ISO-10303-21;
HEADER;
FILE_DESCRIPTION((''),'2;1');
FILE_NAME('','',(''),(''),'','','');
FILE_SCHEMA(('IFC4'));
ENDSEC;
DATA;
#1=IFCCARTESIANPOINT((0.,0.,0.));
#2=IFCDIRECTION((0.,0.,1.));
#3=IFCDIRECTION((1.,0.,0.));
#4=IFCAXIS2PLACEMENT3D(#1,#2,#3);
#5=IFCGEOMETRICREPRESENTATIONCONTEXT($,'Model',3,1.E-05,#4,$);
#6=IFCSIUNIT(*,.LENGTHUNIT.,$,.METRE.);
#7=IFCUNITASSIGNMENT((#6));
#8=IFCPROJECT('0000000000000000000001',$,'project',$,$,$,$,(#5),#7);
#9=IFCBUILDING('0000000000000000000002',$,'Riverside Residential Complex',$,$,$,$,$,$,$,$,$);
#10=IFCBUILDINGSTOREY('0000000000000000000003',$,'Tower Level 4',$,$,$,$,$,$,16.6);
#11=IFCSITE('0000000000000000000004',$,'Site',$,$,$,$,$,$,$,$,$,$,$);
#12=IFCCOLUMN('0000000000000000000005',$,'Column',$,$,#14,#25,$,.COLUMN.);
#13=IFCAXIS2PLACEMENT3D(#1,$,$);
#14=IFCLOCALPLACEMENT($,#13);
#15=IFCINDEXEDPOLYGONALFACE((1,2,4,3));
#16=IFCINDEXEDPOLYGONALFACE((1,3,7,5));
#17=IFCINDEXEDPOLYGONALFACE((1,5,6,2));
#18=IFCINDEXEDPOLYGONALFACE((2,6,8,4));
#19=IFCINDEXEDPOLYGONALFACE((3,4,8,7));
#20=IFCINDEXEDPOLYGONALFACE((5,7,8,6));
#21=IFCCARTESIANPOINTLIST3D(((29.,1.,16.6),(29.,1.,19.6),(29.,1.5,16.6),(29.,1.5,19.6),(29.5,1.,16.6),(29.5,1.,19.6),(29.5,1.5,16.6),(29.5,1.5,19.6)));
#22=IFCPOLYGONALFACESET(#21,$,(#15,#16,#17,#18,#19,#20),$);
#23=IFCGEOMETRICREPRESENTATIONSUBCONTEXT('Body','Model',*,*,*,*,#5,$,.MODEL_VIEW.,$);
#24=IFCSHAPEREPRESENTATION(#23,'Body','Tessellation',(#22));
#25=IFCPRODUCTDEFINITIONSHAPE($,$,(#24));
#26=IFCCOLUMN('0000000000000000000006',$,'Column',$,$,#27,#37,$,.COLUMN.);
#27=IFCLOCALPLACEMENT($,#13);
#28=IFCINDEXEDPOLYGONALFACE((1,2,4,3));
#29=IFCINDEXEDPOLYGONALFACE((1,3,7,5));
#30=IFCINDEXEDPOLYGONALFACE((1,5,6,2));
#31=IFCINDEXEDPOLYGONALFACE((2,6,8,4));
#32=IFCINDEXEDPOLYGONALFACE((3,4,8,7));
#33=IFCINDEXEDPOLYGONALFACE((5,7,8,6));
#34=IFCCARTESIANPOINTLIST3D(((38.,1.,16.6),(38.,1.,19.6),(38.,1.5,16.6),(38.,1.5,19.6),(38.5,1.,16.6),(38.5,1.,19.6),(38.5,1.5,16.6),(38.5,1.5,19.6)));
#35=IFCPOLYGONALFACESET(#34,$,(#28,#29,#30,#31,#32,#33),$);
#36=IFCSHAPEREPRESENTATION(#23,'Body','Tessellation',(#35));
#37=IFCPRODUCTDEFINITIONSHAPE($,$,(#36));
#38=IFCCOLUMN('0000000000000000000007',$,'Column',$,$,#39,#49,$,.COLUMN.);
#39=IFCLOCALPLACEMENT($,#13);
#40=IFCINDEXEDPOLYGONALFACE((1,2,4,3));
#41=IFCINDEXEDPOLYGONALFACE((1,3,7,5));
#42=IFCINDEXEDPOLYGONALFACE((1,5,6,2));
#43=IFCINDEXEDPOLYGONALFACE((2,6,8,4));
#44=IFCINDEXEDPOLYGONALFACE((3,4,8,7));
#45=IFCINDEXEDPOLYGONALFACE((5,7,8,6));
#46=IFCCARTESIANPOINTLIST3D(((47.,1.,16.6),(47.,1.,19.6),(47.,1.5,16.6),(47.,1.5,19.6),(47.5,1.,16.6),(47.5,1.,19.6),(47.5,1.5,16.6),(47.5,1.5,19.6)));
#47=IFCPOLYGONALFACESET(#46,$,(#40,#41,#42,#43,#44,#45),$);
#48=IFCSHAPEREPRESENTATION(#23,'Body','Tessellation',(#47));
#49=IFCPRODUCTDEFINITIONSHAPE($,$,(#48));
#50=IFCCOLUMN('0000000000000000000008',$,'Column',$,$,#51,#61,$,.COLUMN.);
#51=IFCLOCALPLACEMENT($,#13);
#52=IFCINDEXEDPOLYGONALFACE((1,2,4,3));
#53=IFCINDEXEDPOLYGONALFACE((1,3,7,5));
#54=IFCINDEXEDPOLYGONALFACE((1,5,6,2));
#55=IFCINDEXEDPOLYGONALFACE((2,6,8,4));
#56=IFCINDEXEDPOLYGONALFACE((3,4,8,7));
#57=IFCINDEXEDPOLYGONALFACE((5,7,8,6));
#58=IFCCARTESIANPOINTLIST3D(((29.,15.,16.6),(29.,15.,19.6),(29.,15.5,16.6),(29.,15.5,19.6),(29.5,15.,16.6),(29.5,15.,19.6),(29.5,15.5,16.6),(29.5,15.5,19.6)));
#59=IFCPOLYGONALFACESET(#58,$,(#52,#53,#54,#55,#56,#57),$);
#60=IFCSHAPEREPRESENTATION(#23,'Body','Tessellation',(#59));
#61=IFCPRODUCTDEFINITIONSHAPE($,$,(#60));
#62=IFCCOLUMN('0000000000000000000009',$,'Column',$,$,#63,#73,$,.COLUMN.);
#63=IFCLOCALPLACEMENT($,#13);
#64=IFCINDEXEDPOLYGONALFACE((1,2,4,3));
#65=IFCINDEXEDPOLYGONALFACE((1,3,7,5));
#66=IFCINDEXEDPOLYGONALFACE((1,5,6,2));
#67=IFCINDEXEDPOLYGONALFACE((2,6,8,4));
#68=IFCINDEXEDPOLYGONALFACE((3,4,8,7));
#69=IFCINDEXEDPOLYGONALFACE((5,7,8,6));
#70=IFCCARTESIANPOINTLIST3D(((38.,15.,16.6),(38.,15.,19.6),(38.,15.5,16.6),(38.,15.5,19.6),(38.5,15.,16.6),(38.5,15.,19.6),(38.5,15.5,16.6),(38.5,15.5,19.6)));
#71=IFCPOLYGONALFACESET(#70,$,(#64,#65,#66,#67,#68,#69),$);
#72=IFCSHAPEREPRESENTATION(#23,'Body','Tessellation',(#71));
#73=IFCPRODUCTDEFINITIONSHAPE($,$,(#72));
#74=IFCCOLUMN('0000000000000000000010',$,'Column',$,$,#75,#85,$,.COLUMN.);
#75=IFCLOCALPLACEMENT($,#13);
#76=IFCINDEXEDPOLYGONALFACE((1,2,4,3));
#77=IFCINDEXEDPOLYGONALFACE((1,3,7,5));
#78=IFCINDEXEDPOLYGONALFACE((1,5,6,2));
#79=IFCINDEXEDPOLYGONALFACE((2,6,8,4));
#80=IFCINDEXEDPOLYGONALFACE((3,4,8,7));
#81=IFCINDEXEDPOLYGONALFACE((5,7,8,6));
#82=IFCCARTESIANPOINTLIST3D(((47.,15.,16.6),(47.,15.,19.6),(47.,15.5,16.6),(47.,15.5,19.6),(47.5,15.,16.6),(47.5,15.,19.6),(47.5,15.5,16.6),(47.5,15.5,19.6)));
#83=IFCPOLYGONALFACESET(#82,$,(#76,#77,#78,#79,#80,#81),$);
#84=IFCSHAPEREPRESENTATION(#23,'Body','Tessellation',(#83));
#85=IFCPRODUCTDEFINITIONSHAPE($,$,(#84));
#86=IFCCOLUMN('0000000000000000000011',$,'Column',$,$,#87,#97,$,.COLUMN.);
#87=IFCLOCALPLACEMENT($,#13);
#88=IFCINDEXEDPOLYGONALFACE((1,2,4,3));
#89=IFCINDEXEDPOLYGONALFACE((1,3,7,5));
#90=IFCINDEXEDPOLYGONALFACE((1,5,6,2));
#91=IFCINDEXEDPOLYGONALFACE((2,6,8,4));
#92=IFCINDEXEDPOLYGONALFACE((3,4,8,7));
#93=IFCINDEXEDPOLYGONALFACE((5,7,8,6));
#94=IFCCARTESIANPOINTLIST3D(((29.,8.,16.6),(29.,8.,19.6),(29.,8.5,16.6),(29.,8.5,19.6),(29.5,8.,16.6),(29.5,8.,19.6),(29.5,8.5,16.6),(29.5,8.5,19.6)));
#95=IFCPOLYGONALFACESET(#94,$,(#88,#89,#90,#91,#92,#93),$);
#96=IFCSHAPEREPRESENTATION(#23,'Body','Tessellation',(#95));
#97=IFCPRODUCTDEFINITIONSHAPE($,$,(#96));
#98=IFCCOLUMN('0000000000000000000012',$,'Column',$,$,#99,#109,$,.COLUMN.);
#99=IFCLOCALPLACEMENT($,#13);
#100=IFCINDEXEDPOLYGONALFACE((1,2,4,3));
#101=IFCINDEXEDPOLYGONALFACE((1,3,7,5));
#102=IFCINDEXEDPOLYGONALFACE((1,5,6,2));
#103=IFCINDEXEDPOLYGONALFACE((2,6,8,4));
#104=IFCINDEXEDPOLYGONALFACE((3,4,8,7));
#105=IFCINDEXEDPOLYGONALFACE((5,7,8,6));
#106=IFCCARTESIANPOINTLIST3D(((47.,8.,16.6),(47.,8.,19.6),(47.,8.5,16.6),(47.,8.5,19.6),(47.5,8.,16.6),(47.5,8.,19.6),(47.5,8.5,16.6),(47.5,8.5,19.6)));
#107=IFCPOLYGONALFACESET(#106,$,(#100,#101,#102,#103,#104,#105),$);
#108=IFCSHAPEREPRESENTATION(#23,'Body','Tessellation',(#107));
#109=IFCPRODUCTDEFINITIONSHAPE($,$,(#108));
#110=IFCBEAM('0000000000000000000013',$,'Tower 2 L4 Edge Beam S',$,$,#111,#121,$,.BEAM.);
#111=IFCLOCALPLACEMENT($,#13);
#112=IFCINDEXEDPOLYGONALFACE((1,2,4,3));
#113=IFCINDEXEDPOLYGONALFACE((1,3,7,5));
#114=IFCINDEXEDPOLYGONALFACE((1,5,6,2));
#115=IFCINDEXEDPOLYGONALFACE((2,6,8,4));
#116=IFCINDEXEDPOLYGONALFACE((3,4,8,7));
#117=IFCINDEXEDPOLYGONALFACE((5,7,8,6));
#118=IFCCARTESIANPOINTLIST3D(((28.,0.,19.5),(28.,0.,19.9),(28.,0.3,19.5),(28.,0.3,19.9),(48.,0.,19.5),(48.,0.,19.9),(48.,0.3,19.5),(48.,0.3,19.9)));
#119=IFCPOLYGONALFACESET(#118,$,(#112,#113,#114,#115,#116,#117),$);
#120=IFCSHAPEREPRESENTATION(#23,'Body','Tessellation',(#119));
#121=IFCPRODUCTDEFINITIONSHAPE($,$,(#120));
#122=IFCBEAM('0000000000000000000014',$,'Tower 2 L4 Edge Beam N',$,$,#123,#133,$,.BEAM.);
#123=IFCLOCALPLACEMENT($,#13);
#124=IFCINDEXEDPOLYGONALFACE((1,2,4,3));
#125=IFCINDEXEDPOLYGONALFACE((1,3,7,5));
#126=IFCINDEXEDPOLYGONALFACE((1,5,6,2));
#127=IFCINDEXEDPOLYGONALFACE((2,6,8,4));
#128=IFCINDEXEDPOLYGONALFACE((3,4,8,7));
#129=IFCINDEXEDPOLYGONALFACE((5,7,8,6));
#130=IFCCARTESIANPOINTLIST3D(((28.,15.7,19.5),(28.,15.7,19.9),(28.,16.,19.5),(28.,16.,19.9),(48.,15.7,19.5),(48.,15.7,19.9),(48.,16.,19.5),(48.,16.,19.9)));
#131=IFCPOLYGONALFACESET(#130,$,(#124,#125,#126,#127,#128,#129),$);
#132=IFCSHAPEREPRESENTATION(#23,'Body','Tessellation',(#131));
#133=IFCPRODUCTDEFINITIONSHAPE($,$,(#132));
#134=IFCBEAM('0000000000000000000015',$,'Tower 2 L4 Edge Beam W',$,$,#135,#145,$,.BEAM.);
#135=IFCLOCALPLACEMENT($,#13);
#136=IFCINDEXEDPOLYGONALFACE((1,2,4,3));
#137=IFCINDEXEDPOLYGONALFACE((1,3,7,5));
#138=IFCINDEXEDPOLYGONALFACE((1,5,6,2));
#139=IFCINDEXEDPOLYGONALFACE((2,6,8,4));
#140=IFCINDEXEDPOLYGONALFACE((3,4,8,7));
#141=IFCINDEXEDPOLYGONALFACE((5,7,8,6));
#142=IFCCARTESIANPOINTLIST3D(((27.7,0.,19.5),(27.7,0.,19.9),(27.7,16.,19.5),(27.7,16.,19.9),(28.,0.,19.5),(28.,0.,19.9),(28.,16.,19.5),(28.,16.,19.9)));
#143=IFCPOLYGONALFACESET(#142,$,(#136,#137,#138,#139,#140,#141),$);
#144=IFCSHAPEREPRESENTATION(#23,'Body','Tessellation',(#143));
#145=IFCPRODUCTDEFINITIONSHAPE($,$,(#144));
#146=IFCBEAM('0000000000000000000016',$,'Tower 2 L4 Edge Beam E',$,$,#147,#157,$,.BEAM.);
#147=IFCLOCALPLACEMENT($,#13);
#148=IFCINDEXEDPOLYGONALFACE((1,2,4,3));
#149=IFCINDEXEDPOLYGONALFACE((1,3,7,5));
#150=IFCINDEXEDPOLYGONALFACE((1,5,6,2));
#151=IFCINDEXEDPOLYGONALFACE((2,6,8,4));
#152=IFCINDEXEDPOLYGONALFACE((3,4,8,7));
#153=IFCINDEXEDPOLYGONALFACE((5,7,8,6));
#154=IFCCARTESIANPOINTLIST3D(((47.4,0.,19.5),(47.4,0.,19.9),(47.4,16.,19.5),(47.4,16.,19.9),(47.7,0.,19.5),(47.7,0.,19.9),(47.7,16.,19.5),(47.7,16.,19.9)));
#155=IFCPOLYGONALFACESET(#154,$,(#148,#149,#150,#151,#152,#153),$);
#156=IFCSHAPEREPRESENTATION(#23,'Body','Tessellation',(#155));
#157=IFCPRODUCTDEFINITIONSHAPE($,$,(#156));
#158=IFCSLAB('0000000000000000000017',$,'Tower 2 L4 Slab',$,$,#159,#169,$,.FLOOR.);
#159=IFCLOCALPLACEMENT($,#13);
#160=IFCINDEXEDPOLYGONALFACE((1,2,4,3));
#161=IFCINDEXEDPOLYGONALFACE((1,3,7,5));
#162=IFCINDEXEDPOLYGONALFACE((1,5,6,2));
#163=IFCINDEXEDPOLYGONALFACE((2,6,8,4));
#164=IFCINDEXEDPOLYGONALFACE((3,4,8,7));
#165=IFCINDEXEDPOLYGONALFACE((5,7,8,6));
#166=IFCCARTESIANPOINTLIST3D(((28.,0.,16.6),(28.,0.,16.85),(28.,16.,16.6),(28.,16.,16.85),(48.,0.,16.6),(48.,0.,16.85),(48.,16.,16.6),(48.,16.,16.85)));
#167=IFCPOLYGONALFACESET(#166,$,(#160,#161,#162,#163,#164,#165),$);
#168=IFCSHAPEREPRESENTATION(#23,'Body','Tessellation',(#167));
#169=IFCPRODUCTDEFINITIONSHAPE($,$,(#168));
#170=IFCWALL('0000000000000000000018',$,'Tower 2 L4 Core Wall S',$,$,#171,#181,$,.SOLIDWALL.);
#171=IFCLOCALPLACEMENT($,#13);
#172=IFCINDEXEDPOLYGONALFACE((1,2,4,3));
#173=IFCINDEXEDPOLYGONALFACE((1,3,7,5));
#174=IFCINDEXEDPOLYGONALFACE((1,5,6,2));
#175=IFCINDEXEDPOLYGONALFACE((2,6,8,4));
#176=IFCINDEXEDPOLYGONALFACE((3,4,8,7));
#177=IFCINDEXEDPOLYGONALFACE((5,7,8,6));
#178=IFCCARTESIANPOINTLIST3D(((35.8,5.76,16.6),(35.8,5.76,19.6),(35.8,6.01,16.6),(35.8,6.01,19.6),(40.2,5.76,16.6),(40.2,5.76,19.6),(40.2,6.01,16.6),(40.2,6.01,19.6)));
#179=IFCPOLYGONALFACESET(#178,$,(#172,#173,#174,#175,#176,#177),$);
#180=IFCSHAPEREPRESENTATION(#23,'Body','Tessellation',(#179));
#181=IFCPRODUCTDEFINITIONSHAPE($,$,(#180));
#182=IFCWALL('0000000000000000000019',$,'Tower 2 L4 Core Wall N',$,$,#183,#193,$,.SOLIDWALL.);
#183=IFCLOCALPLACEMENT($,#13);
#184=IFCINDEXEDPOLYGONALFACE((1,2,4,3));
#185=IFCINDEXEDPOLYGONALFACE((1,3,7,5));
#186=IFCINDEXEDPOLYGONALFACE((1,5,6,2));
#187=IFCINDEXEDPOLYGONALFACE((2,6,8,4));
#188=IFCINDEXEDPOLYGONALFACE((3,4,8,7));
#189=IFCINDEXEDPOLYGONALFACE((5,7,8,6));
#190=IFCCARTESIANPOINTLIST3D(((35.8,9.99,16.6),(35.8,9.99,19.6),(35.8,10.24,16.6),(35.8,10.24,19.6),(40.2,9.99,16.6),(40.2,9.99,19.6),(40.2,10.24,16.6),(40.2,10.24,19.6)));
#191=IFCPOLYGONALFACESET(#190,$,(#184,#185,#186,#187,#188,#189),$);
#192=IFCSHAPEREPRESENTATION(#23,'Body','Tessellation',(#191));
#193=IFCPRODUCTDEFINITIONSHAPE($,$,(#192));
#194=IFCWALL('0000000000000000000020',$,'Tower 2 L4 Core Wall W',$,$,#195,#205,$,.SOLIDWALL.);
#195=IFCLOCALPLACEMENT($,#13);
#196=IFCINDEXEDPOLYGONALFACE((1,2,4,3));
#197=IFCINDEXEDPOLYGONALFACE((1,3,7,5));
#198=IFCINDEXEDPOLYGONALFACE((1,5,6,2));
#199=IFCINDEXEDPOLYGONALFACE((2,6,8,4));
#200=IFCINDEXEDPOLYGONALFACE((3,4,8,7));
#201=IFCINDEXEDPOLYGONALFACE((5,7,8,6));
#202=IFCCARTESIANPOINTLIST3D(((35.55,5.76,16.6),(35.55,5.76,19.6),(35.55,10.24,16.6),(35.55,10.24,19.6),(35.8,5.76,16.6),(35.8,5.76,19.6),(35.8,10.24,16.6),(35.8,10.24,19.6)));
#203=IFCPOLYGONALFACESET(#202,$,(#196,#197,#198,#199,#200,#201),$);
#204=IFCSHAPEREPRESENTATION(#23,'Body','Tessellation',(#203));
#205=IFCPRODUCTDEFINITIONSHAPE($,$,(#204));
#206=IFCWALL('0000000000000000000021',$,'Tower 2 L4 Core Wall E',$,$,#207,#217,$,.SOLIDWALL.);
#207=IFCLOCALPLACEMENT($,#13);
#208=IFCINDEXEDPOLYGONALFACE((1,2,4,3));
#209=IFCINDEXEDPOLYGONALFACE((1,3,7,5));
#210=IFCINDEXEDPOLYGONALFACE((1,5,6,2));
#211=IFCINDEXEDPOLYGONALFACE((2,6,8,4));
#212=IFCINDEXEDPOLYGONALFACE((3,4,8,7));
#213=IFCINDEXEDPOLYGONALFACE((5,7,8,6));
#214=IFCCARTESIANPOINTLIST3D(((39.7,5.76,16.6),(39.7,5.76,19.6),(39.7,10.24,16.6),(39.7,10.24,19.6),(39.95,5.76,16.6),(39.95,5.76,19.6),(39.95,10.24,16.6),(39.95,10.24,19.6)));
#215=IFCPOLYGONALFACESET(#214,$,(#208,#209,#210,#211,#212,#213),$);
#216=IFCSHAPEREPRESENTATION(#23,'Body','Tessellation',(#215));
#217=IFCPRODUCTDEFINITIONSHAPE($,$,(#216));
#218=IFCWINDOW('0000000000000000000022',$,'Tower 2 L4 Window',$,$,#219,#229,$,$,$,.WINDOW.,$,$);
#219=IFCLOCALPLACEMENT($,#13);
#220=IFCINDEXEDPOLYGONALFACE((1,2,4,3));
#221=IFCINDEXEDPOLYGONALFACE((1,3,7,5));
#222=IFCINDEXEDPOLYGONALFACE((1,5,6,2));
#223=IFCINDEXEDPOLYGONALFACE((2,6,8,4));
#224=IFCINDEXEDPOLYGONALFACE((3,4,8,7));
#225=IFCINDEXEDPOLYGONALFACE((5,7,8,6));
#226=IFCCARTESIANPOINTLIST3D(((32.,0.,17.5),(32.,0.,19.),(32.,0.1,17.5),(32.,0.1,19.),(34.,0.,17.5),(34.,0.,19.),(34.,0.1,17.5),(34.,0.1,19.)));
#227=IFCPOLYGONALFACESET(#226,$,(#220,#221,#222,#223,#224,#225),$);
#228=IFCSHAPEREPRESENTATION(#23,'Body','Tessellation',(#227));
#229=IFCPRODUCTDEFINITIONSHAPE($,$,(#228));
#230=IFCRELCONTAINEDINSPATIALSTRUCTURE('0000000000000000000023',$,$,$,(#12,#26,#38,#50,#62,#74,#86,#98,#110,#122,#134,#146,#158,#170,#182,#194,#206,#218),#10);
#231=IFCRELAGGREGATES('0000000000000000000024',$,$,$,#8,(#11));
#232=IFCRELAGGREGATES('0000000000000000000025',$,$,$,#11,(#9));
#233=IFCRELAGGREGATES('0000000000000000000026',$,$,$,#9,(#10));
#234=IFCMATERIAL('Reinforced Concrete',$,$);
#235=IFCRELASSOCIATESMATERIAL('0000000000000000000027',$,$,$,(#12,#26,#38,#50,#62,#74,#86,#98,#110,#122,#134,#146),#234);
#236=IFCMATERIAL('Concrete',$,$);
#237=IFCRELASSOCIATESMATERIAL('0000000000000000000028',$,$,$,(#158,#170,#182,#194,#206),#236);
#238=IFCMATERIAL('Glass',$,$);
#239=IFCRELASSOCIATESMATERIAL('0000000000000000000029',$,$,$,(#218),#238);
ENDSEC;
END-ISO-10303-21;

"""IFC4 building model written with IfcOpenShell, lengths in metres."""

from ifc_helpers import new_model, si_unit, frame, origin_with_axes, place, context, subcontext, project, spatial, line, indexed_curve, outline, extrude, material, element, save


model = new_model("IFC4")

# Units and contexts
model_context = context("Model", 3, precision=1e-05, world=origin_with_axes())
body_context = subcontext(model_context, "Body", "Model", "MODEL_VIEW")
ifc_project = project(units=[si_unit("LENGTHUNIT", "METRE")], contexts=[model_context])

# Site, building, storey
site = spatial("IfcSite", under=ifc_project, Name="Site")
building = spatial("IfcBuilding", under=site, Name="Riverside Residential Complex")
storey = spatial("IfcBuildingStorey", under=building, Name="Tower Level 4", Elevation=16.6)

# Columns
ifc_material_1 = material(Name="Reinforced Concrete")
for number, where, z_axis, x_axis, name in (
    (1, (29.0, 1.0, 16.6), (0.0, 0.0, 1.0), (1.0, 0.0, 0.0), "Column"),
    (2, (38.0, 1.0, 16.6), (0.0, 0.0, 1.0), (1.0, 0.0, 0.0), "Column"),
    (3, (47.0, 1.0, 16.6), (0.0, 0.0, 1.0), (1.0, 0.0, 0.0), "Column"),
    (4, (29.0, 15.0, 16.6), (0.0, 0.0, 1.0), (1.0, 0.0, 0.0), "Column"),
    (5, (38.0, 15.0, 16.6), (0.0, 0.0, 1.0), (1.0, 0.0, 0.0), "Column"),
    (6, (47.0, 15.0, 16.6), (0.0, 0.0, 1.0), (1.0, 0.0, 0.0), "Column"),
    (7, (29.0, 8.0, 16.6), (0.0, 0.0, 1.0), (1.0, 0.0, 0.0), "Column"),
    (8, (47.0, 8.0, 16.6), (0.0, 0.0, 1.0), (1.0, 0.0, 0.0), "Column"),
):
    element("IfcColumn", number, at=place(None, frame(where, z_axis=z_axis, x_axis=x_axis)), inside=storey, material=ifc_material_1, Name=name, PredefinedType="COLUMN", context=body_context, shape_type="SweptSolid", body=[
        extrude(outline(indexed_curve([(0.0, 0.0), (0.5, 0.0), (0.5, 0.5), (0.0, 0.5)], segments=[line(1, 2, 3, 4, 1)])), origin_with_axes(), (0.0, 0.0, 1.0), 3.0),
    ])

# Beams
for number, where, z_axis, x_axis, name in (
    (9, (28.0, 0.0, 19.5), (0.0, 0.0, 1.0), (1.0, 0.0, 0.0), "Tower 2 L4 Edge Beam S"),
    (10, (28.0, 15.7, 19.5), (0.0, 0.0, 1.0), (1.0, 0.0, 0.0), "Tower 2 L4 Edge Beam N"),
):
    element("IfcBeam", number, at=place(None, frame(where, z_axis=z_axis, x_axis=x_axis)), inside=storey, material=ifc_material_1, Name=name, PredefinedType="BEAM", context=body_context, shape_type="SweptSolid", body=[
        extrude(outline(indexed_curve([(0.0, 0.0), (20.0, 0.0), (20.0, 0.3), (0.0, 0.3)], segments=[line(1, 2, 3, 4, 1)])), origin_with_axes(), (0.0, 0.0, 1.0), 0.4),
    ])
for number, where, z_axis, x_axis, name in (
    (11, (28.0, 0.0, 19.5), (0.0, 0.0, 1.0), (0.0, 1.0, 0.0), "Tower 2 L4 Edge Beam W"),
    (12, (47.7, 0.0, 19.5), (0.0, 0.0, 1.0), (0.0, 1.0, 0.0), "Tower 2 L4 Edge Beam E"),
):
    element("IfcBeam", number, at=place(None, frame(where, z_axis=z_axis, x_axis=x_axis)), inside=storey, material=ifc_material_1, Name=name, PredefinedType="BEAM", context=body_context, shape_type="SweptSolid", body=[
        extrude(outline(indexed_curve([(0.0, 0.0), (16.0, 0.0), (16.0, 0.3), (0.0, 0.3)], segments=[line(1, 2, 3, 4, 1)])), origin_with_axes(), (0.0, 0.0, 1.0), 0.4),
    ])

# Slab
ifc_material_2 = material(Name="Concrete")
slab_placement = place(None, frame((28.0, 0.0, 16.6), z_axis=(0.0, 0.0, 1.0), x_axis=(1.0, 0.0, 0.0)))
element("IfcSlab", 13, at=slab_placement, inside=storey, material=ifc_material_2, Name="Tower 2 L4 Slab", PredefinedType="FLOOR", context=body_context, shape_type="SweptSolid", body=[
    extrude(outline(indexed_curve([(0.0, 0.0), (20.0, 0.0), (20.0, 16.0), (0.0, 16.0)], segments=[line(1, 2, 3, 4, 1)])), origin_with_axes(), (0.0, 0.0, 1.0), 0.25),
])

# Walls
for number, where, z_axis, x_axis, name in (
    (14, (35.8, 5.76, 16.6), (0.0, 0.0, 1.0), (1.0, 0.0, 0.0), "Tower 2 L4 Core Wall S"),
    (15, (35.8, 9.99, 16.6), (0.0, 0.0, 1.0), (1.0, 0.0, 0.0), "Tower 2 L4 Core Wall N"),
):
    element("IfcWall", number, at=place(None, frame(where, z_axis=z_axis, x_axis=x_axis)), inside=storey, material=ifc_material_2, Name=name, PredefinedType="SOLIDWALL", context=body_context, shape_type="SweptSolid", body=[
        extrude(outline(indexed_curve([(0.0, 0.0), (4.4, 0.0), (4.4, 0.25), (0.0, 0.25)], segments=[line(1, 2, 3, 4, 1)])), origin_with_axes(), (0.0, 0.0, 1.0), 3.0),
    ])
for number, where, z_axis, x_axis, name in (
    (16, (35.8, 5.76, 16.6), (0.0, 0.0, 1.0), (0.0, 1.0, 0.0), "Tower 2 L4 Core Wall W"),
    (17, (39.95, 5.76, 16.6), (0.0, 0.0, 1.0), (0.0, 1.0, 0.0), "Tower 2 L4 Core Wall E"),
):
    element("IfcWall", number, at=place(None, frame(where, z_axis=z_axis, x_axis=x_axis)), inside=storey, material=ifc_material_2, Name=name, PredefinedType="SOLIDWALL", context=body_context, shape_type="SweptSolid", body=[
        extrude(outline(indexed_curve([(0.0, 0.0), (4.48, 0.0), (4.48, 0.25), (0.0, 0.25)], segments=[line(1, 2, 3, 4, 1)])), origin_with_axes(), (0.0, 0.0, 1.0), 3.0),
    ])

# Window
ifc_material_3 = material(Name="Glass")
for number, where, z_axis, x_axis, name in (
    (18, (32.0, 0.0, 17.5), (0.0, 0.0, 1.0), (1.0, 0.0, 0.0), "Tower 2 L4 Window"),
):
    element("IfcWindow", number, at=place(None, frame(where, z_axis=z_axis, x_axis=x_axis)), inside=storey, material=ifc_material_3, Name=name, PredefinedType="WINDOW", context=body_context, shape_type="SweptSolid", body=[
        extrude(outline(indexed_curve([(0.0, 0.0), (2.0, 0.0), (2.0, 0.1), (0.0, 0.1)], segments=[line(1, 2, 3, 4, 1)])), origin_with_axes(), (0.0, 0.0, 1.0), 1.5),
    ])

save(model, "model.ifc")
